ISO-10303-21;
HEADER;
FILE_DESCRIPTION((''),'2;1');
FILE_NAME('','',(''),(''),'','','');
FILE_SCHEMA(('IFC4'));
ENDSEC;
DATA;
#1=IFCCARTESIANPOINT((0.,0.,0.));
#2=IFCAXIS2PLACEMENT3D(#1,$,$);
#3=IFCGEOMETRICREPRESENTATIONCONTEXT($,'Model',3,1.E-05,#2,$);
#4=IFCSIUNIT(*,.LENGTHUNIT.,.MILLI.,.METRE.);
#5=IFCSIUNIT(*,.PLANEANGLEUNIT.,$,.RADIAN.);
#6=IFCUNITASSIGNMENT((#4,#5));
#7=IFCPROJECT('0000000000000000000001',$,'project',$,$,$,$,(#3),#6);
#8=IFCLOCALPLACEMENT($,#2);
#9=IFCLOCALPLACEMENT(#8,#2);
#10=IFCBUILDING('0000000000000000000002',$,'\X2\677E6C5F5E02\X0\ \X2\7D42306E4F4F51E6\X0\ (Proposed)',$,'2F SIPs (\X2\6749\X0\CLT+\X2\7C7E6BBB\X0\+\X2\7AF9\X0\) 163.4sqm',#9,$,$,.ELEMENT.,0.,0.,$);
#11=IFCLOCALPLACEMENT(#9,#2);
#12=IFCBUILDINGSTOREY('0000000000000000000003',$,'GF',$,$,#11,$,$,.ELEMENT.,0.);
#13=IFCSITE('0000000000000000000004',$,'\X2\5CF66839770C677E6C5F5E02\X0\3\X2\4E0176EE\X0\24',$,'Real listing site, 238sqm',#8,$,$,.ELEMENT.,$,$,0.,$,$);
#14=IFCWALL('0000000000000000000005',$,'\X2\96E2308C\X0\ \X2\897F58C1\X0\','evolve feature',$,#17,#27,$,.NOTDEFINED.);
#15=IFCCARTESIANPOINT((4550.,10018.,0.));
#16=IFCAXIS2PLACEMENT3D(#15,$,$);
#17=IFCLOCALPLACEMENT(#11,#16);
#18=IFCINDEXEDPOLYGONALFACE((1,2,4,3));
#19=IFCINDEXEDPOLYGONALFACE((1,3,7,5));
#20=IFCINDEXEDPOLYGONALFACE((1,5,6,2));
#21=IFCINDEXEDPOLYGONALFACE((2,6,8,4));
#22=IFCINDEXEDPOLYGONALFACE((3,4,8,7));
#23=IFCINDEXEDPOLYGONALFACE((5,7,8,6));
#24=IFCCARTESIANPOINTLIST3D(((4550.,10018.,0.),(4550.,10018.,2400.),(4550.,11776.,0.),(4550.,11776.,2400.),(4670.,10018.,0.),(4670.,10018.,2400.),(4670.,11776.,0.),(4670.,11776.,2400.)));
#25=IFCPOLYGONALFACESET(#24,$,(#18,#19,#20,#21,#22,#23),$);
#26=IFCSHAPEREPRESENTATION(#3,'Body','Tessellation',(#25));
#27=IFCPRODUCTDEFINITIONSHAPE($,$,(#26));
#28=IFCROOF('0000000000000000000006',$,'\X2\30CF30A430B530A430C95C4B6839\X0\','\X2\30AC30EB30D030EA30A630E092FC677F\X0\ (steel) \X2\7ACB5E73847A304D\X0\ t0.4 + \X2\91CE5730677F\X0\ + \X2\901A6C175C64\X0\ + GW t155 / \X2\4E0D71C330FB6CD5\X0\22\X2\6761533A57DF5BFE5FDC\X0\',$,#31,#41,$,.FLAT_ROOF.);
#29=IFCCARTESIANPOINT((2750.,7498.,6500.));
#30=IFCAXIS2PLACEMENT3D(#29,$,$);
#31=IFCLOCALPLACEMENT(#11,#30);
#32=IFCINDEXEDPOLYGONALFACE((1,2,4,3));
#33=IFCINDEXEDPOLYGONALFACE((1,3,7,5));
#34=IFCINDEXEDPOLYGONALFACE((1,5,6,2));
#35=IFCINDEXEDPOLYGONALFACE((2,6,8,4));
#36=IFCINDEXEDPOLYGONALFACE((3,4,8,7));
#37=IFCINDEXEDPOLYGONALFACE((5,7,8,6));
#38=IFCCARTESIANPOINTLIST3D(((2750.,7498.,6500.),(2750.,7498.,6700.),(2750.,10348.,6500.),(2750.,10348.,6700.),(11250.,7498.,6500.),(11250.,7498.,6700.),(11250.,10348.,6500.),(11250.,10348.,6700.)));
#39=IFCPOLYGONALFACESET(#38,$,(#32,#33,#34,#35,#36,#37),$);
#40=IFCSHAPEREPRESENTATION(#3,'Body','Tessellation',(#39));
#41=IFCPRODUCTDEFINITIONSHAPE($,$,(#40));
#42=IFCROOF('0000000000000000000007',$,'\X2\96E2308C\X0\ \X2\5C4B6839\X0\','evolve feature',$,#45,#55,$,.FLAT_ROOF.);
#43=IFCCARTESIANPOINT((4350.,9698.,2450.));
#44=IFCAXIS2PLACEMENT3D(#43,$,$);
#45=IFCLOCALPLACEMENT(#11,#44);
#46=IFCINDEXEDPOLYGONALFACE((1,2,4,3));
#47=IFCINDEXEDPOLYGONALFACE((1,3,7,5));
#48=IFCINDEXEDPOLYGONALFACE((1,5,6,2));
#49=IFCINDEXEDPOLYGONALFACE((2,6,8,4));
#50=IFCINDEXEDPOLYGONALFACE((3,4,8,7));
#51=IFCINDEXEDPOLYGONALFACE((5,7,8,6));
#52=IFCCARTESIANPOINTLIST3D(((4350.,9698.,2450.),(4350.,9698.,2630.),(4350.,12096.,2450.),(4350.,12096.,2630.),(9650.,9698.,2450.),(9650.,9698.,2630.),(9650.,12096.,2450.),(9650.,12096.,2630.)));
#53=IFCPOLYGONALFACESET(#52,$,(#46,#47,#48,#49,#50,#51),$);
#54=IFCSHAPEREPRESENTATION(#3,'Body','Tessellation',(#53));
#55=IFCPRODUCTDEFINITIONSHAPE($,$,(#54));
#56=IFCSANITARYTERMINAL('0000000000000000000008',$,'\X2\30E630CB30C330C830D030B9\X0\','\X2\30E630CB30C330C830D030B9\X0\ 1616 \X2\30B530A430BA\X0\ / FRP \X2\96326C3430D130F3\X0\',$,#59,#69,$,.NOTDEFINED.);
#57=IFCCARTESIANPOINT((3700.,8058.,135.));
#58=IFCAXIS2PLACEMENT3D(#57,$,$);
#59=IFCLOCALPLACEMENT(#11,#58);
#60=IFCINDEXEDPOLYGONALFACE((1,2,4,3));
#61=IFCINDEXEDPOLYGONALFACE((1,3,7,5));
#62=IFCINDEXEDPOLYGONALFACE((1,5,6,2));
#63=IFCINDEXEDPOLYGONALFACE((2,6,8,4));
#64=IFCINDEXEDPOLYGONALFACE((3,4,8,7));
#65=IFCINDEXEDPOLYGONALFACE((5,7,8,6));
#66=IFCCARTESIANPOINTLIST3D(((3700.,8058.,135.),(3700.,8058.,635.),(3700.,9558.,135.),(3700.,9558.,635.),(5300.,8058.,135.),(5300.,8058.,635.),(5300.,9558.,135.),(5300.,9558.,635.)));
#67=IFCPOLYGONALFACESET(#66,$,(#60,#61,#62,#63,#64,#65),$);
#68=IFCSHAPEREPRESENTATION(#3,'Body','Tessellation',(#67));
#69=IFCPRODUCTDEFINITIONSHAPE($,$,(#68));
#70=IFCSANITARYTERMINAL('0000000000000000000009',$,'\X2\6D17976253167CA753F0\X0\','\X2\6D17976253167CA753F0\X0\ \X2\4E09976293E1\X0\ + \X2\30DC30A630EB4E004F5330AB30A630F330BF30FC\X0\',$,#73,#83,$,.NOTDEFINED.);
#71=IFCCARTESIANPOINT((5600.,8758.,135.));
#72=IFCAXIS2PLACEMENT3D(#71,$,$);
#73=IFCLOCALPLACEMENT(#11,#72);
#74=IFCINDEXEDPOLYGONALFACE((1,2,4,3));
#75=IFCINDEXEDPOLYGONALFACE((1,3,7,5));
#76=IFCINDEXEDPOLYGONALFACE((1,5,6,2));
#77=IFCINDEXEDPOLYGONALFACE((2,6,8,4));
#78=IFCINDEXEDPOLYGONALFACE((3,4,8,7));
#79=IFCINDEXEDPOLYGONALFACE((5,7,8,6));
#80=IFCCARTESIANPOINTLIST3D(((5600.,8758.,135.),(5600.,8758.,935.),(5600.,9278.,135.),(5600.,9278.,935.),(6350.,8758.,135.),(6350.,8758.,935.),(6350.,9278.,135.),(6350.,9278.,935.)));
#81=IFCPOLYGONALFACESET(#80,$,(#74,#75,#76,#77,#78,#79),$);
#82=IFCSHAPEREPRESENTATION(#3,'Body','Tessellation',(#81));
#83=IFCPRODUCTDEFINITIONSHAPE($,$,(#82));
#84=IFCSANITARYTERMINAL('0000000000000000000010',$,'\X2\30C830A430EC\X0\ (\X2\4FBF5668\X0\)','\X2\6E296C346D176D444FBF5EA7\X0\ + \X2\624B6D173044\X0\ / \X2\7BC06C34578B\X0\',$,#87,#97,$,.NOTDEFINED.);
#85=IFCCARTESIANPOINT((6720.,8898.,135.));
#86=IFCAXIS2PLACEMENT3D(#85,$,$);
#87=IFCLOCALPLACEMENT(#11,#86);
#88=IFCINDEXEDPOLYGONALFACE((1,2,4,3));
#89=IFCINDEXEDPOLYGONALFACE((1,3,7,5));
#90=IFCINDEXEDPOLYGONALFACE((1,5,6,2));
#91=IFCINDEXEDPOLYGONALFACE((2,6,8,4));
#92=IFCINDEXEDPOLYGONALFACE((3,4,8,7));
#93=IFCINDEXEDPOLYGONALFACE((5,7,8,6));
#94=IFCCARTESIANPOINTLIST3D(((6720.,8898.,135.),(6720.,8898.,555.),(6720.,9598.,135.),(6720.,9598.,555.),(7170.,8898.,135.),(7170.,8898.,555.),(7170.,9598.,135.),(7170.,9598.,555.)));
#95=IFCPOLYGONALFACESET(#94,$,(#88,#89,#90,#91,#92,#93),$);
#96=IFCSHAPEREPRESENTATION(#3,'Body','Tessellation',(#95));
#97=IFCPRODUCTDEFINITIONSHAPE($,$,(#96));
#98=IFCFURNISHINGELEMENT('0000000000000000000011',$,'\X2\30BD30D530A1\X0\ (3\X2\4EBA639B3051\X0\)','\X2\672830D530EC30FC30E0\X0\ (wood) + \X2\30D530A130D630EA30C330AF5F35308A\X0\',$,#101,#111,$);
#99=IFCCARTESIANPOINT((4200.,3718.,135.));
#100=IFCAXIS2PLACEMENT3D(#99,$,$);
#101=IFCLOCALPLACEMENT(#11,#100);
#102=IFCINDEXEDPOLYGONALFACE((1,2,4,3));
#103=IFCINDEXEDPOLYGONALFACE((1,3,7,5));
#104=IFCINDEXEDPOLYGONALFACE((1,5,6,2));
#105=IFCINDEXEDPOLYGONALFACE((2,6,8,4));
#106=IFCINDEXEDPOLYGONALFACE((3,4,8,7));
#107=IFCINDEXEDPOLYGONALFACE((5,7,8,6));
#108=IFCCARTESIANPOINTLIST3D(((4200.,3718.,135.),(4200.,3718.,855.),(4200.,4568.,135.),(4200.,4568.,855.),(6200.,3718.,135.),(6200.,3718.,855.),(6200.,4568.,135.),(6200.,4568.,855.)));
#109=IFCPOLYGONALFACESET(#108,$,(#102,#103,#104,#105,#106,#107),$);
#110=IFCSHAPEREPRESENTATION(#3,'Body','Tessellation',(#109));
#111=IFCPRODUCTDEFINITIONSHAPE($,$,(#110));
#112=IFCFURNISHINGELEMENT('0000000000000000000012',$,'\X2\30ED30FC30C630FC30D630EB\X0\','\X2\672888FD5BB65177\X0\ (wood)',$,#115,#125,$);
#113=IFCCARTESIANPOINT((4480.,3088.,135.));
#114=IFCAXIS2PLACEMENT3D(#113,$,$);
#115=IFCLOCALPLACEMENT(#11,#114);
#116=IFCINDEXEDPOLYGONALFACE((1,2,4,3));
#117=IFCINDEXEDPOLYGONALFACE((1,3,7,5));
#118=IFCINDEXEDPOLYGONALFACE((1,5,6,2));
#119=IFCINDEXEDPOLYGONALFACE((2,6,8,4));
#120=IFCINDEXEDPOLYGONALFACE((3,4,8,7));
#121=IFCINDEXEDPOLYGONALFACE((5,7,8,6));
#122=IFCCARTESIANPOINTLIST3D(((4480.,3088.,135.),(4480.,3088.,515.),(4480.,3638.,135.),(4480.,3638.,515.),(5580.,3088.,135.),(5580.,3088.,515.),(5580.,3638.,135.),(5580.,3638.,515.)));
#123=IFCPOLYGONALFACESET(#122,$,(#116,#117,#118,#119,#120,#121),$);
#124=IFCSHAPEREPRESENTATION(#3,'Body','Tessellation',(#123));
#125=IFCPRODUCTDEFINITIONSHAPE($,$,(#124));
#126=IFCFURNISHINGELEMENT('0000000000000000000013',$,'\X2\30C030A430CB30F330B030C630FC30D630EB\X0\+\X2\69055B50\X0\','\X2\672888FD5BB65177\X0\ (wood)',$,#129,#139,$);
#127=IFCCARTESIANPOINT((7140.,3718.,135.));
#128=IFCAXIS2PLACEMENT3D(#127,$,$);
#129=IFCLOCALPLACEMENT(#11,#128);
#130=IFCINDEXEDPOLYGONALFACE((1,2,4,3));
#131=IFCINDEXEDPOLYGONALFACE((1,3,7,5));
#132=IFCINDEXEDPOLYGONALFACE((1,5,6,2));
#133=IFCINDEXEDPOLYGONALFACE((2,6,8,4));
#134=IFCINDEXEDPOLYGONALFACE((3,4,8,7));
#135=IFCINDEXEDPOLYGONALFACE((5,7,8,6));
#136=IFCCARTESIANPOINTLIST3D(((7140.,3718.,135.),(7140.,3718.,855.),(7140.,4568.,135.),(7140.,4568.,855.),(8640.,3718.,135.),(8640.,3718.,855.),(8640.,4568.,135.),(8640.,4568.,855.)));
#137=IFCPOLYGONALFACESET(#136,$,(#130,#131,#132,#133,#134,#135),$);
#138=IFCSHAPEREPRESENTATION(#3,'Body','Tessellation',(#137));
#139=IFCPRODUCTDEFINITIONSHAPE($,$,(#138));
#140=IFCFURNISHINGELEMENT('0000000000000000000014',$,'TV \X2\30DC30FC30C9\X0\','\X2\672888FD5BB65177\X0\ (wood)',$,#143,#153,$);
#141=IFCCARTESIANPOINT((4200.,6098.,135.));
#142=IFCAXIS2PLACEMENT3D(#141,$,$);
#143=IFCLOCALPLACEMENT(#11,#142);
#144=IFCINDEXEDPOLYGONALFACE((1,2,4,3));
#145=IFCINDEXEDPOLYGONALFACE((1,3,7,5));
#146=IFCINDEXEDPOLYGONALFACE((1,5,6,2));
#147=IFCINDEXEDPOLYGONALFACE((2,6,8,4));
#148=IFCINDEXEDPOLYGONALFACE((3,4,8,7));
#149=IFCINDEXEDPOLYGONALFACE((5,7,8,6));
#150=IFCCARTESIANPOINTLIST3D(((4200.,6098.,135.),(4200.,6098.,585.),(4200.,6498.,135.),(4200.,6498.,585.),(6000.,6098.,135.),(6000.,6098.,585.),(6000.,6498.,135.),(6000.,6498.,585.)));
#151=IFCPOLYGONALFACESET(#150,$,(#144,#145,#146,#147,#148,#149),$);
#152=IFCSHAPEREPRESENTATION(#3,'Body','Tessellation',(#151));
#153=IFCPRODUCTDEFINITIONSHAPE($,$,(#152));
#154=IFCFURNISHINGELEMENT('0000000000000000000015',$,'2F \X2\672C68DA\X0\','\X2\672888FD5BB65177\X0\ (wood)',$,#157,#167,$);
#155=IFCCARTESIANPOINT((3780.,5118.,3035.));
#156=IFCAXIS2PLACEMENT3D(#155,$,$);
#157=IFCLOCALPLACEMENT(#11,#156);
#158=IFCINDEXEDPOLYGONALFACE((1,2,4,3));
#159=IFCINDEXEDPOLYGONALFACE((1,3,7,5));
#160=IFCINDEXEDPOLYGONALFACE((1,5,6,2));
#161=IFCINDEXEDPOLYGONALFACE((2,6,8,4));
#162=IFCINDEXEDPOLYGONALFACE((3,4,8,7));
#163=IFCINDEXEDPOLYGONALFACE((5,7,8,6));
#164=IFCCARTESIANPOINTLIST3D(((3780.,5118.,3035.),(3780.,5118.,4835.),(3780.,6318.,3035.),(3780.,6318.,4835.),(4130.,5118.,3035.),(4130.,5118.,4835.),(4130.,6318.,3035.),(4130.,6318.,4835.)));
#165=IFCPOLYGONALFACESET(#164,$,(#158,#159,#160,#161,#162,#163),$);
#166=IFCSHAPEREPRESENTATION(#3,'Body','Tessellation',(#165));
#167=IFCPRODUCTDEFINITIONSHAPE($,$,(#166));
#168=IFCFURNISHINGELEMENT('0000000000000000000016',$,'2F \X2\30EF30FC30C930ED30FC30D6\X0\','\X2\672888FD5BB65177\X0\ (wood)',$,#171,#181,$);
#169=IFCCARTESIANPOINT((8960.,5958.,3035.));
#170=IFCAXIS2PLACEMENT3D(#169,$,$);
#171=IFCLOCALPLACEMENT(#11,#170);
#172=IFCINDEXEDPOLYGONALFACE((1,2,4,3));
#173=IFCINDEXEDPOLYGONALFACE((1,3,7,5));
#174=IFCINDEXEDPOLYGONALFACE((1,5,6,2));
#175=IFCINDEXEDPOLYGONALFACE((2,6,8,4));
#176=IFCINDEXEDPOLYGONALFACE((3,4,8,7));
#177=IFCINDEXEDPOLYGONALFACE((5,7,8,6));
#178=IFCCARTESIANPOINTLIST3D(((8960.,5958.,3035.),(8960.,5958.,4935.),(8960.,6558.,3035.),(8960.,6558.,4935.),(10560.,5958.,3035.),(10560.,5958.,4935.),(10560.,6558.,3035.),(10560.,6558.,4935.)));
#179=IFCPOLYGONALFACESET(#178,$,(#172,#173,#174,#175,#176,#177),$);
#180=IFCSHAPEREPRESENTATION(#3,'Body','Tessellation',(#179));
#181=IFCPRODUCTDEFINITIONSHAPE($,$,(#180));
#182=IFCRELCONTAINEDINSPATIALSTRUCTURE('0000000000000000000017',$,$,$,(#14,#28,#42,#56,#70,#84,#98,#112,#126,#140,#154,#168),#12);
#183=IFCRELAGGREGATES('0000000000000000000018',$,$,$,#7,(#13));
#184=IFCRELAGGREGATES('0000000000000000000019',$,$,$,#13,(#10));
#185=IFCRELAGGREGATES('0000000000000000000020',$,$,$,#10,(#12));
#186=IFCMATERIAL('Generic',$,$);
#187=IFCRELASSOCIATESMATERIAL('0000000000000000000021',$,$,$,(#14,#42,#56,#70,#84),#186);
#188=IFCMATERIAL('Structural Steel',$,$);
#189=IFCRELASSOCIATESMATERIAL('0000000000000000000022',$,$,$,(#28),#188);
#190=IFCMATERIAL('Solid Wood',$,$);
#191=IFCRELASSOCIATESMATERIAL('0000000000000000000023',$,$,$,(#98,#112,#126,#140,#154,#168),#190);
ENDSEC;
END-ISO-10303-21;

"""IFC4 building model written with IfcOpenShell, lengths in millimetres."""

from ifc_helpers import new_model, si_unit, frame, frame_2d, origin, place, context, project, spatial, rectangle, extrude, material, element, save


model = new_model("IFC4")

# Units and contexts
model_context = context("Model", 3, precision=1e-05, world=origin())
ifc_project = project(units=[si_unit("LENGTHUNIT", "METRE", prefix="MILLI"), si_unit("PLANEANGLEUNIT", "RADIAN")], contexts=[model_context])

# Site, building, storey
site_placement = place(None, origin())
site = spatial("IfcSite", under=ifc_project, at=site_placement, Name="島根県松江市3丁目24", ObjectType="Real listing site, 238sqm", CompositionType="ELEMENT", RefElevation=0.0)
building_placement = place(site_placement, origin())
building = spatial("IfcBuilding", under=site, at=building_placement, Name="松江市 終の住処 (Proposed)", ObjectType="2F SIPs (杉CLT+籾殻+竹) 163.4sqm", CompositionType="ELEMENT", ElevationOfRefHeight=0.0, ElevationOfTerrain=0.0)
storey_placement = place(building_placement, origin())
storey = spatial("IfcBuildingStorey", under=building, at=storey_placement, Name="GF", CompositionType="ELEMENT", Elevation=0.0)

# Shared definitions
ifc_material_1 = material(Name="Generic")

# Shared definitions
ifc_material_2 = material(Name="Solid Wood")

# Wall
wall_1_placement = place(storey_placement, frame((4550.0, 10018.0, 0.0)))
element("IfcWall", 1, at=wall_1_placement, inside=storey, material=ifc_material_1, Name="離れ 西壁", Description="evolve feature", PredefinedType="NOTDEFINED", context=model_context, shape_type="SweptSolid", body=[
    extrude(rectangle(XDim=120.0, YDim=1758.0, at=frame_2d((60.0, 879.0))), frame((4550.0, 10018.0, 0.0)), (0.0, 0.0, 1.0), 2400.0),
])

# Roofs
ifc_material_3 = material(Name="Structural Steel")
roof_1_placement = place(storey_placement, frame((2750.0, 7498.0, 6500.0)))
element("IfcRoof", 2, at=roof_1_placement, inside=storey, material=ifc_material_3, Name="ハイサイド屋根", Description="ガルバリウム鋼板 (steel) 立平葺き t0.4 + 野地板 + 通気層 + GW t155 / 不燃・法22条区域対応", PredefinedType="FLAT_ROOF", context=model_context, shape_type="SweptSolid", body=[
    extrude(rectangle(XDim=8500.0, YDim=2850.0, at=frame_2d((4250.0, 1425.0))), frame((2750.0, 7498.0, 6500.0)), (0.0, 0.0, 1.0), 200.0),
])
roof_2_placement = place(storey_placement, frame((4350.0, 9698.0, 2450.0)))
element("IfcRoof", 3, at=roof_2_placement, inside=storey, material=ifc_material_1, Name="離れ 屋根", Description="evolve feature", PredefinedType="FLAT_ROOF", context=model_context, shape_type="SweptSolid", body=[
    extrude(rectangle(XDim=5300.0, YDim=2398.0, at=frame_2d((2650.0, 1199.0))), frame((4350.0, 9698.0, 2450.0)), (0.0, 0.0, 1.0), 180.0),
])

# Sanitary terminals
sanitary_terminal_1_placement = place(storey_placement, frame((3700.0, 8058.0, 135.0)))
element("IfcSanitaryTerminal", 4, at=sanitary_terminal_1_placement, inside=storey, material=ifc_material_1, Name="ユニットバス", Description="ユニットバス 1616 サイズ / FRP 防水パン", PredefinedType="NOTDEFINED", context=model_context, shape_type="SweptSolid", body=[
    extrude(rectangle(XDim=1600.0, YDim=1500.0, at=frame_2d((800.0, 750.0))), frame((3700.0, 8058.0, 135.0)), (0.0, 0.0, 1.0), 500.0),
])
sanitary_terminal_2_placement = place(storey_placement, frame((5600.0, 8758.0, 135.0)))
element("IfcSanitaryTerminal", 5, at=sanitary_terminal_2_placement, inside=storey, material=ifc_material_1, Name="洗面化粧台", Description="洗面化粧台 三面鏡 + ボウル一体カウンター", PredefinedType="NOTDEFINED", context=model_context, shape_type="SweptSolid", body=[
    extrude(rectangle(XDim=750.0, YDim=520.0, at=frame_2d((375.0, 260.0))), frame((5600.0, 8758.0, 135.0)), (0.0, 0.0, 1.0), 800.0),
])
sanitary_terminal_3_placement = place(storey_placement, frame((6720.0, 8898.0, 135.0)))
element("IfcSanitaryTerminal", 6, at=sanitary_terminal_3_placement, inside=storey, material=ifc_material_1, Name="トイレ (便器)", Description="温水洗浄便座 + 手洗い / 節水型", PredefinedType="NOTDEFINED", context=model_context, shape_type="SweptSolid", body=[
    extrude(rectangle(XDim=450.0, YDim=700.0, at=frame_2d((225.0, 350.0))), frame((6720.0, 8898.0, 135.0)), (0.0, 0.0, 1.0), 420.0),
])

# Furnishing elements
furnishing_1_placement = place(storey_placement, frame((4200.0, 3718.0, 135.0)))
element("IfcFurnishingElement", 7, at=furnishing_1_placement, inside=storey, material=ifc_material_2, Name="ソファ (3人掛け)", Description="木フレーム (wood) + ファブリック張り", context=model_context, shape_type="SweptSolid", body=[
    extrude(rectangle(XDim=2000.0, YDim=850.0, at=frame_2d((1000.0, 425.0))), frame((4200.0, 3718.0, 135.0)), (0.0, 0.0, 1.0), 720.0),
])
furnishing_2_placement = place(storey_placement, frame((4480.0, 3088.0, 135.0)))
element("IfcFurnishingElement", 8, at=furnishing_2_placement, inside=storey, material=ifc_material_2, Name="ローテーブル", Description="木製家具 (wood)", context=model_context, shape_type="SweptSolid", body=[
    extrude(rectangle(XDim=1100.0, YDim=550.0, at=frame_2d((550.0, 275.0))), frame((4480.0, 3088.0, 135.0)), (0.0, 0.0, 1.0), 380.0),
])
furnishing_3_placement = place(storey_placement, frame((7140.0, 3718.0, 135.0)))
element("IfcFurnishingElement", 9, at=furnishing_3_placement, inside=storey, material=ifc_material_2, Name="ダイニングテーブル+椅子", Description="木製家具 (wood)", context=model_context, shape_type="SweptSolid", body=[
    extrude(rectangle(XDim=1500.0, YDim=850.0, at=frame_2d((750.0, 425.0))), frame((7140.0, 3718.0, 135.0)), (0.0, 0.0, 1.0), 720.0),
])
furnishing_4_placement = place(storey_placement, frame((4200.0, 6098.0, 135.0)))
element("IfcFurnishingElement", 10, at=furnishing_4_placement, inside=storey, material=ifc_material_2, Name="TV ボード", Description="木製家具 (wood)", context=model_context, shape_type="SweptSolid", body=[
    extrude(rectangle(XDim=1800.0, YDim=400.0, at=frame_2d((900.0, 200.0))), frame((4200.0, 6098.0, 135.0)), (0.0, 0.0, 1.0), 450.0),
])
furnishing_5_placement = place(storey_placement, frame((3780.0, 5118.0, 3035.0)))
element("IfcFurnishingElement", 11, at=furnishing_5_placement, inside=storey, material=ifc_material_2, Name="2F 本棚", Description="木製家具 (wood)", context=model_context, shape_type="SweptSolid", body=[
    extrude(rectangle(XDim=350.0, YDim=1200.0, at=frame_2d((175.0, 600.0))), frame((3780.0, 5118.0, 3035.0)), (0.0, 0.0, 1.0), 1800.0),
])
furnishing_6_placement = place(storey_placement, frame((8960.0, 5958.0, 3035.0)))
element("IfcFurnishingElement", 12, at=furnishing_6_placement, inside=storey, material=ifc_material_2, Name="2F ワードローブ", Description="木製家具 (wood)", context=model_context, shape_type="SweptSolid", body=[
    extrude(rectangle(XDim=1600.0, YDim=600.0, at=frame_2d((800.0, 300.0))), frame((8960.0, 5958.0, 3035.0)), (0.0, 0.0, 1.0), 1900.0),
])

save(model, "model.ifc")
